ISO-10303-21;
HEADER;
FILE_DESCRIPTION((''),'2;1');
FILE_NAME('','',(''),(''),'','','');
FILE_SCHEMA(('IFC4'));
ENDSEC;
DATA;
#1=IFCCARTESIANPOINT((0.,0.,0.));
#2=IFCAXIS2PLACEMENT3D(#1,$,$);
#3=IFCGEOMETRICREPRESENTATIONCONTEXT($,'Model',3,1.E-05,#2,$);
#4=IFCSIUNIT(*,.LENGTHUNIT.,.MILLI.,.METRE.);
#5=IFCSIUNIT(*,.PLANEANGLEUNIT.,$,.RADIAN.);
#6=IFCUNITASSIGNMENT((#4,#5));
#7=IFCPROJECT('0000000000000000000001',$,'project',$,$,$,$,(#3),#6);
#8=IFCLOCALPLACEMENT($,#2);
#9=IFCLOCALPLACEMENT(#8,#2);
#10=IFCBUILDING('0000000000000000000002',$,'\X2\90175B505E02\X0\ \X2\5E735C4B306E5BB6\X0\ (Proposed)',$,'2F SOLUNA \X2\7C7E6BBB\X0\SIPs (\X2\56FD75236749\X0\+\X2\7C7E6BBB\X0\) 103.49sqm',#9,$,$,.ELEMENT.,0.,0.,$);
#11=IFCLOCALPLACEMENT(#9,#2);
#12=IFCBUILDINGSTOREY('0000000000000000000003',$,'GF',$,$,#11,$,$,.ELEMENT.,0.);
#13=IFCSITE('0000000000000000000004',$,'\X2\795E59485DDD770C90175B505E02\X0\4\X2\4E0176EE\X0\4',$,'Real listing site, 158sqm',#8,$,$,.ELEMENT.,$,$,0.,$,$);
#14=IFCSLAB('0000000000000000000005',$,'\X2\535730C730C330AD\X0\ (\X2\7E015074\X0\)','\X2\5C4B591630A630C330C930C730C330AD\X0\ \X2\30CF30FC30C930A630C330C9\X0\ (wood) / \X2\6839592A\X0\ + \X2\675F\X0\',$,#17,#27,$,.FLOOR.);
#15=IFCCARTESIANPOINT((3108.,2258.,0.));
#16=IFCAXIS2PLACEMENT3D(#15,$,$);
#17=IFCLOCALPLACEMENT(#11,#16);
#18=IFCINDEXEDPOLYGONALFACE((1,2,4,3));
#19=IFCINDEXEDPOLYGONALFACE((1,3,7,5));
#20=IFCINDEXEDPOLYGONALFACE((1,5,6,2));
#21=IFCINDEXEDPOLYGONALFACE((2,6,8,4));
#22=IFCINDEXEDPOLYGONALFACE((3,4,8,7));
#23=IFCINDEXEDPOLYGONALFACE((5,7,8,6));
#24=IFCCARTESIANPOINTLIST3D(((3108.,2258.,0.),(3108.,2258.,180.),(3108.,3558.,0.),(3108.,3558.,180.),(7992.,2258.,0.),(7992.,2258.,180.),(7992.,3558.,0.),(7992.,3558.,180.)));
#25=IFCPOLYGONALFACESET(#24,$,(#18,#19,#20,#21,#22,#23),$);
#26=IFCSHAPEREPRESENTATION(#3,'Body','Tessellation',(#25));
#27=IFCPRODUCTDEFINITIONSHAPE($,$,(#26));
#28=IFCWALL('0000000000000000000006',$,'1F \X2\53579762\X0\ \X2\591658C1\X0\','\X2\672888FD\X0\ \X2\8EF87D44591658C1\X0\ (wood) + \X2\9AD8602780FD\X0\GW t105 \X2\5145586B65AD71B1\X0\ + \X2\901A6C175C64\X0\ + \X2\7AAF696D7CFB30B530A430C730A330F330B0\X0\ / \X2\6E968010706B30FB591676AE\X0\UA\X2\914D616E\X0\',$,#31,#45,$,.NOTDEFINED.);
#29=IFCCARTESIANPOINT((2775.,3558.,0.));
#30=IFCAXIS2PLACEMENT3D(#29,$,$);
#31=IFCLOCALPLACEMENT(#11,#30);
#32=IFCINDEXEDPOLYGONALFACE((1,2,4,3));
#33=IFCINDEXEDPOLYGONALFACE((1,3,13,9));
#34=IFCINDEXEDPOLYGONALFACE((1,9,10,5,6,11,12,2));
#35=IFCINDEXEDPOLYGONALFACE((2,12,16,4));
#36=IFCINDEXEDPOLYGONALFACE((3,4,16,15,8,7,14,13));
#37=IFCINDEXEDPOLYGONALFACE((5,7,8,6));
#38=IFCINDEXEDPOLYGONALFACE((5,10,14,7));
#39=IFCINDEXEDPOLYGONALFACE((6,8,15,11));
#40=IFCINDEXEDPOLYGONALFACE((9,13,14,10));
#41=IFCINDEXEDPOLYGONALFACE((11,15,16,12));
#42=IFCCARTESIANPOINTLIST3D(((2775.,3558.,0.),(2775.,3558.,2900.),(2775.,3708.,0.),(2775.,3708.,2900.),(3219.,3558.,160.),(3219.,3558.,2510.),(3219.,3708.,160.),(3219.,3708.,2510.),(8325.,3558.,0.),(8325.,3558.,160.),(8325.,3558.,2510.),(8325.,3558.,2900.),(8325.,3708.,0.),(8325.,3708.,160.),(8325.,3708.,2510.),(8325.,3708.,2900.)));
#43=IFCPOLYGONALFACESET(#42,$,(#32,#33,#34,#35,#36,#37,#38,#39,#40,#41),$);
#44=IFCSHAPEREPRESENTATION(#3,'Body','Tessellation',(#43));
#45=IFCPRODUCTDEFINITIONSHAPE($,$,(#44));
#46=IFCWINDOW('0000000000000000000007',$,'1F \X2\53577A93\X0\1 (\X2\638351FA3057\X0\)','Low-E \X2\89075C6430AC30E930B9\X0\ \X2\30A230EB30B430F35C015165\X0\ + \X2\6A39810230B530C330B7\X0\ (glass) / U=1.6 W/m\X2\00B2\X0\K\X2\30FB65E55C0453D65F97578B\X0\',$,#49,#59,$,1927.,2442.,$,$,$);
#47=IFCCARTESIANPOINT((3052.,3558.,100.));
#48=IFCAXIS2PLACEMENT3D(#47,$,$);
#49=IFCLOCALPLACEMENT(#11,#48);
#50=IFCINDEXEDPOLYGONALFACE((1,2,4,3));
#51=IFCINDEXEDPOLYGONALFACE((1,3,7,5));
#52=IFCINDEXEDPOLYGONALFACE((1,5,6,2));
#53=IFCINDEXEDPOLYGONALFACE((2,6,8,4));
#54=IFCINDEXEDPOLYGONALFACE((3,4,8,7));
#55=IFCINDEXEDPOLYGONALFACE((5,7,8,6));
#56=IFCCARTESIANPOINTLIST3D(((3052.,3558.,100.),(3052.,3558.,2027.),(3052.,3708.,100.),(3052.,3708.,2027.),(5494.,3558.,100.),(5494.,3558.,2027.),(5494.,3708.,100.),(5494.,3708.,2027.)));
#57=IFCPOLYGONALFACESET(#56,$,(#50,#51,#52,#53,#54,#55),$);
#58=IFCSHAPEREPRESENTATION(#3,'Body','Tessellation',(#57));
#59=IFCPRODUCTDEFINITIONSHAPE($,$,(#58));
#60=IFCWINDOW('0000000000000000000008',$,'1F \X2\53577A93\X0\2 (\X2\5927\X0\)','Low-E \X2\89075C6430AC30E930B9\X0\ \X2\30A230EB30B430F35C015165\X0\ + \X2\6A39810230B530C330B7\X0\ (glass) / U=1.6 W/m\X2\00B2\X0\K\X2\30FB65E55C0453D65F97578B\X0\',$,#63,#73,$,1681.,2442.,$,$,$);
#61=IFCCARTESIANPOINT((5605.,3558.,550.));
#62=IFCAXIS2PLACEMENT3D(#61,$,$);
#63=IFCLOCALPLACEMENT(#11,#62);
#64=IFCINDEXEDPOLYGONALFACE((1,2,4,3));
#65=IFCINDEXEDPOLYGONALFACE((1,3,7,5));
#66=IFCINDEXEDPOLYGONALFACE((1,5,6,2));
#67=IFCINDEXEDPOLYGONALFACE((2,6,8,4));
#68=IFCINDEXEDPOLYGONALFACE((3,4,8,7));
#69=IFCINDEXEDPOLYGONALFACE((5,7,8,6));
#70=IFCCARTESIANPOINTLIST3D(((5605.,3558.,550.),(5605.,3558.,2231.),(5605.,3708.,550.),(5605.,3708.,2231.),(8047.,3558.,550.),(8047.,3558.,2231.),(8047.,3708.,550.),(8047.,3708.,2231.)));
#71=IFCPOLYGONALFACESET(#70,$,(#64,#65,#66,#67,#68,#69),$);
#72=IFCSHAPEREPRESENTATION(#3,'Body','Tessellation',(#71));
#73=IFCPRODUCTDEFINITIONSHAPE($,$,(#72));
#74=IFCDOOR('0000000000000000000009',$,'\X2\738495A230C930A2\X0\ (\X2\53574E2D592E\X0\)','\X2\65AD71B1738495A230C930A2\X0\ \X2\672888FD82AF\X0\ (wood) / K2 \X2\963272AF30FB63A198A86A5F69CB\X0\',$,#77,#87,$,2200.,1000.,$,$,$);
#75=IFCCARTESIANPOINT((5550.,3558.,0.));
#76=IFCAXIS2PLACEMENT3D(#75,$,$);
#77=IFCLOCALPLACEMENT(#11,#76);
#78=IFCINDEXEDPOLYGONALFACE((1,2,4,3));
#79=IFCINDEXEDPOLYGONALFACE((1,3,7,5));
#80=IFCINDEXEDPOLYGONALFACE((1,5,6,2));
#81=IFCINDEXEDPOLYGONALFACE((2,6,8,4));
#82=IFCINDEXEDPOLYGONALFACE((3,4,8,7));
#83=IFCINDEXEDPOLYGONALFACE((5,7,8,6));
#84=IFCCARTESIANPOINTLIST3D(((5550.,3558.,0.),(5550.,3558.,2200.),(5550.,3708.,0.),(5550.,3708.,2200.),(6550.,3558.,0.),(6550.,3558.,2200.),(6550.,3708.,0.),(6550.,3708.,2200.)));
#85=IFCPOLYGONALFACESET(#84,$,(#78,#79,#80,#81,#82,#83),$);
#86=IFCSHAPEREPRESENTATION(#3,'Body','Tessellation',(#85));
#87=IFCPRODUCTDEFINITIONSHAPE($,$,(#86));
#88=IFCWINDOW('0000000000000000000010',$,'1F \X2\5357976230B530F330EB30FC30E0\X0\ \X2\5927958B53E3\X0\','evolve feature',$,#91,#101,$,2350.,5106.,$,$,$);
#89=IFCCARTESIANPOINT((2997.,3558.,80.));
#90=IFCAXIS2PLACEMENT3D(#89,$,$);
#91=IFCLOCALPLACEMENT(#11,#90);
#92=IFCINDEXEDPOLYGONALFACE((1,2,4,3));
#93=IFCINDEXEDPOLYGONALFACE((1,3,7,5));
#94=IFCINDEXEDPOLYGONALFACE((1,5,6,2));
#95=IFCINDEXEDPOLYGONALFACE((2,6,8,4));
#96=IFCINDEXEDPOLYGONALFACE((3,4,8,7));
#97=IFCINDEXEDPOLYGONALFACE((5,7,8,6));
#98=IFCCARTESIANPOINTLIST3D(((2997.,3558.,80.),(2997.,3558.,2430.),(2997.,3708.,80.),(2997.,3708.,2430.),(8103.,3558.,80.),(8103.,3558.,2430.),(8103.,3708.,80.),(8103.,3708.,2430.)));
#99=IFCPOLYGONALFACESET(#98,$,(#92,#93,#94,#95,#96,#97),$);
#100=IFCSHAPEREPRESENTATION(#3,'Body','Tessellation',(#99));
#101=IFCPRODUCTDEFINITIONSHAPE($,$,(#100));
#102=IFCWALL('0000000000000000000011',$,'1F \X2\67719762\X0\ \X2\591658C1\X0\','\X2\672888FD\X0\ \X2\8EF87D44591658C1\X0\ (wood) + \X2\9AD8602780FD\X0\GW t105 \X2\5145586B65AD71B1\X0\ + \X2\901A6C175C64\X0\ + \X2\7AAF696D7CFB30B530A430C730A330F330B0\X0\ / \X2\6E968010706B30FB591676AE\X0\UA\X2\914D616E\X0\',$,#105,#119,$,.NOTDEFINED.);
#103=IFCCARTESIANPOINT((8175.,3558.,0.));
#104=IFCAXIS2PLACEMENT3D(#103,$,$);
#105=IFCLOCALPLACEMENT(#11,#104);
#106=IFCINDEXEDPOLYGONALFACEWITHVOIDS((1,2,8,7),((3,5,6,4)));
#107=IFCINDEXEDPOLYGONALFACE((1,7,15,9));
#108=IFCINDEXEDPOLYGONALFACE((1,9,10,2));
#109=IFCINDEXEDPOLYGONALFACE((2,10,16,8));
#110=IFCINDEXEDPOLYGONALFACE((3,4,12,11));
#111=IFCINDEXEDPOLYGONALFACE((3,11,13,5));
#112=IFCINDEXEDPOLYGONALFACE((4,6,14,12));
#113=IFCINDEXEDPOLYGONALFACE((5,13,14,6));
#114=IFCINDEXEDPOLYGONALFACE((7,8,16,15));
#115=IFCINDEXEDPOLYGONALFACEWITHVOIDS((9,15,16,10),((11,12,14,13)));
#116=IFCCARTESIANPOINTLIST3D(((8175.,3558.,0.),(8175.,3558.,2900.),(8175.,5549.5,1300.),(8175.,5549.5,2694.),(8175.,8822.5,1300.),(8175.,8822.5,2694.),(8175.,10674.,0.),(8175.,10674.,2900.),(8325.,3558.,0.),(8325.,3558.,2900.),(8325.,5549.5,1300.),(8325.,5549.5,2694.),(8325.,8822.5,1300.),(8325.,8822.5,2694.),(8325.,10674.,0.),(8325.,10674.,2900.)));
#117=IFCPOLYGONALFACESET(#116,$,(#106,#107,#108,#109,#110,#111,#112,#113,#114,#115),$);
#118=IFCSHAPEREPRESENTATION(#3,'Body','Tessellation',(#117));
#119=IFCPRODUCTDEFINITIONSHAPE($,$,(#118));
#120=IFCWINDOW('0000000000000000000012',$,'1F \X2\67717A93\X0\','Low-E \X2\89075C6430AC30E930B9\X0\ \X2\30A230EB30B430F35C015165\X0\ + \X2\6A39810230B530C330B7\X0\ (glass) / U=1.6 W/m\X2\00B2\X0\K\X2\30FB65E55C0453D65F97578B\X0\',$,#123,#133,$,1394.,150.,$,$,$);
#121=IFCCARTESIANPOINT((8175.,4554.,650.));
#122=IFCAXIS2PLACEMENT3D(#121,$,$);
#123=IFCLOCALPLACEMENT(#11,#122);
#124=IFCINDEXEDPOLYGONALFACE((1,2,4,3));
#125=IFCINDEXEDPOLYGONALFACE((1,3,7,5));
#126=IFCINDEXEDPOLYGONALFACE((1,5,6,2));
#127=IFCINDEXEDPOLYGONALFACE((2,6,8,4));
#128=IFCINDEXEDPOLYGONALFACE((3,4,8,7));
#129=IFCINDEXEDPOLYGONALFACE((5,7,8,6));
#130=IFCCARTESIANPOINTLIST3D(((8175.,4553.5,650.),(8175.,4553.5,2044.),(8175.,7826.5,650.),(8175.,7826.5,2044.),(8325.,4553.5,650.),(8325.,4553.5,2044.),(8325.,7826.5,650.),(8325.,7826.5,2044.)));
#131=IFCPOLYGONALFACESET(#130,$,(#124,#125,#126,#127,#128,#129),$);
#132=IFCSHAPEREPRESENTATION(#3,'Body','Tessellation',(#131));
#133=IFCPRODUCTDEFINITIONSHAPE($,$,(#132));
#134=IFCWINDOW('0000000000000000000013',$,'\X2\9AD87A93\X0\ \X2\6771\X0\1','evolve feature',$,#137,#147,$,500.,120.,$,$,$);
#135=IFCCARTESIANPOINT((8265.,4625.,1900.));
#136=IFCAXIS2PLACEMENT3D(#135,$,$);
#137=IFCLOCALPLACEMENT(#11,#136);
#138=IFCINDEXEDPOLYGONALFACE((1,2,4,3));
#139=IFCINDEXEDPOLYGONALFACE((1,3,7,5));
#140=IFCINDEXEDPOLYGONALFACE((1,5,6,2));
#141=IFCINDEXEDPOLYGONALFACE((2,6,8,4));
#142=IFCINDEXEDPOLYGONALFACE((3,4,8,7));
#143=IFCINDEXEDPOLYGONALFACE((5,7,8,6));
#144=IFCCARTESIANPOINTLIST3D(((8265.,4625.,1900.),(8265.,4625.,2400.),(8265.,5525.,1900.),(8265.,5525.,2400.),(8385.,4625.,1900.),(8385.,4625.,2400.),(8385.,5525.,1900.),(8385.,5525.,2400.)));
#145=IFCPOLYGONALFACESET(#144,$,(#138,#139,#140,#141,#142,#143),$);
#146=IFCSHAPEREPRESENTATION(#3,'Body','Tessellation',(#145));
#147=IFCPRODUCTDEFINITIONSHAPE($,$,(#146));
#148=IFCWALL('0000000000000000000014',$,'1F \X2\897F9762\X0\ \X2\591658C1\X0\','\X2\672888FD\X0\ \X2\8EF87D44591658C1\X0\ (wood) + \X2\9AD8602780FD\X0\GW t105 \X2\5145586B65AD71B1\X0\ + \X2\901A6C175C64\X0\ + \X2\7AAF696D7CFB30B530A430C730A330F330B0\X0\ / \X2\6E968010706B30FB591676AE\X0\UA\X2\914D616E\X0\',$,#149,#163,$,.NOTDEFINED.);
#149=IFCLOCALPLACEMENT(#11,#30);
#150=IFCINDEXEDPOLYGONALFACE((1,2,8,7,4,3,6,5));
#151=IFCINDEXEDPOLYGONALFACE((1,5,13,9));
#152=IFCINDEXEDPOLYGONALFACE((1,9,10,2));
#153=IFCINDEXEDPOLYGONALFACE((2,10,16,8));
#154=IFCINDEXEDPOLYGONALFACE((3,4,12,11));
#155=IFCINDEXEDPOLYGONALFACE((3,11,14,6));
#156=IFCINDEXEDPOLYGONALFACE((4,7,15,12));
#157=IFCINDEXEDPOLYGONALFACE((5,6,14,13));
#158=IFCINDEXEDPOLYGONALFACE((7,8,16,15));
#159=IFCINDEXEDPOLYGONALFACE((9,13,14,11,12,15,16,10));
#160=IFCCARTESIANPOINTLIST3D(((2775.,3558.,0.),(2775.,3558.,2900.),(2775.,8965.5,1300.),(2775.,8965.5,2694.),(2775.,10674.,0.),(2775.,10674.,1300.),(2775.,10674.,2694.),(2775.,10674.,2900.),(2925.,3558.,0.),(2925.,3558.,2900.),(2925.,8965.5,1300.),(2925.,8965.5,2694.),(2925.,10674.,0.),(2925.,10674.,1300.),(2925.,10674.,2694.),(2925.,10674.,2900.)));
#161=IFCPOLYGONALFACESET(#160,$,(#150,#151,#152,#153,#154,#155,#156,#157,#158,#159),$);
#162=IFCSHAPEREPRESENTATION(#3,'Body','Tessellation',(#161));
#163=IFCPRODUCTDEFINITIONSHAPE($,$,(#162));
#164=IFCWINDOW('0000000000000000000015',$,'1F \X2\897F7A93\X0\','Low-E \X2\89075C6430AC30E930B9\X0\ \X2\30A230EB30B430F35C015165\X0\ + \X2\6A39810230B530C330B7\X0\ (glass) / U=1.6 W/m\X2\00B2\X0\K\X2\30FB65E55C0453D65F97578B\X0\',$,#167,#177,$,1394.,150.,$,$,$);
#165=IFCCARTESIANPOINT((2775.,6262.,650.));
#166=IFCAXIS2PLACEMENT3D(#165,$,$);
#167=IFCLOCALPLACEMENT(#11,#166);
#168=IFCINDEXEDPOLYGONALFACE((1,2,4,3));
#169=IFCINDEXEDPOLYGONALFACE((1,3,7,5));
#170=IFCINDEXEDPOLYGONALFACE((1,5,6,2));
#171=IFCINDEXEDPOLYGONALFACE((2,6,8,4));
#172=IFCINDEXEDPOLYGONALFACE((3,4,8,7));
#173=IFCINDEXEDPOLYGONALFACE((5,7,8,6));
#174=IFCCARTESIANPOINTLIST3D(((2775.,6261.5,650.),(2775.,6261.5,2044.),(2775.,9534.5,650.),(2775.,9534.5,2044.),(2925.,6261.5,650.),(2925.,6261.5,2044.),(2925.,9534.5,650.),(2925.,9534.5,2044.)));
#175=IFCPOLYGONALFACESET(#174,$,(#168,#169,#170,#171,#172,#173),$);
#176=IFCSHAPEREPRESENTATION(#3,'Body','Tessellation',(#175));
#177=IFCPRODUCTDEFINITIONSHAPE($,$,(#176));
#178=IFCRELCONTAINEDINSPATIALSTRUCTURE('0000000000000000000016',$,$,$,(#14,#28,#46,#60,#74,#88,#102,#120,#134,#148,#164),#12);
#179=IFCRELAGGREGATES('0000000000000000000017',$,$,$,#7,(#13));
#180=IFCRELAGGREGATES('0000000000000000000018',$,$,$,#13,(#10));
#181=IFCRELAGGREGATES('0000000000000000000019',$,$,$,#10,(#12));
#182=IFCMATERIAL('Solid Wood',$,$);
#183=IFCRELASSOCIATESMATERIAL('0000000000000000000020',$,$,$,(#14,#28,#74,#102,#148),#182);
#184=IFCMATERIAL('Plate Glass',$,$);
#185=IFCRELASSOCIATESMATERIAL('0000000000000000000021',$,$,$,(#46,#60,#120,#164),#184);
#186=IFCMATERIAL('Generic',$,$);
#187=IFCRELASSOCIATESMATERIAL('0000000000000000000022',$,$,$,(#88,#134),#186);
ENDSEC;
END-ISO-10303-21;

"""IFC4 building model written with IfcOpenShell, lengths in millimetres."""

from ifc_helpers import new_model, si_unit, frame, frame_2d, origin, place, context, project, spatial, rectangle, extrude, material, element, fill, save


model = new_model("IFC4")

# Units and contexts
model_context = context("Model", 3, precision=1e-05, world=origin())
ifc_project = project(units=[si_unit("LENGTHUNIT", "METRE", prefix="MILLI"), si_unit("PLANEANGLEUNIT", "RADIAN")], contexts=[model_context])

# Site, building, storey
site_placement = place(None, origin())
site = spatial("IfcSite", under=ifc_project, at=site_placement, Name="神奈川県逗子市4丁目4", ObjectType="Real listing site, 158sqm", CompositionType="ELEMENT", RefElevation=0.0)
building_placement = place(site_placement, origin())
building = spatial("IfcBuilding", under=site, at=building_placement, Name="逗子市 平屋の家 (Proposed)", ObjectType="2F SOLUNA 籾殻SIPs (国産杉+籾殻) 103.49sqm", CompositionType="ELEMENT", ElevationOfRefHeight=0.0, ElevationOfTerrain=0.0)
storey_placement = place(building_placement, origin())
storey = spatial("IfcBuildingStorey", under=building, at=storey_placement, Name="GF", CompositionType="ELEMENT", Elevation=0.0)

# Slab
ifc_material_1 = material(Name="Solid Wood")
slab_1_placement = place(storey_placement, frame((3108.0, 2258.0, 0.0)))
element("IfcSlab", 1, at=slab_1_placement, inside=storey, material=ifc_material_1, Name="南デッキ (縁側)", Description="屋外ウッドデッキ ハードウッド (wood) / 根太 + 束", PredefinedType="FLOOR", context=model_context, shape_type="SweptSolid", body=[
    extrude(rectangle(XDim=4884.0, YDim=1300.0, at=frame_2d((2442.0, 650.0))), frame((3108.0, 2258.0, 0.0)), (0.0, 0.0, 1.0), 180.0),
])
ifc_material_2 = material(Name="Generic")

# Wall, openings, windows, door
wall_1_placement = place(storey_placement, frame((2775.0, 3558.0, 0.0)))
wall_1 = element("IfcWall", 2, at=wall_1_placement, inside=storey, material=ifc_material_1, Name="1F 南面 外壁", Description="木製 軸組外壁 (wood) + 高性能GW t105 充填断熱 + 通気層 + 窯業系サイディング / 準耐火・外皮UA配慮", PredefinedType="NOTDEFINED", context=model_context, shape_type="SweptSolid", body=[
    extrude(rectangle(XDim=5550.0, YDim=150.0, at=frame_2d((2775.0, 75.0))), frame((2775.0, 3558.0, 0.0)), (0.0, 0.0, 1.0), 2900.0),
])
opening_1_placement = place(storey_placement, frame((3052.0, 3558.0, 100.0)))
opening_1 = element("IfcOpeningElement", 3, at=opening_1_placement, cuts=wall_1, PredefinedType="NOTDEFINED", context=model_context, shape_type="SweptSolid", body=[
    extrude(rectangle(XDim=2442.0, YDim=150.0, at=frame_2d((1221.0, 75.0))), frame((3052.0, 3558.0, 100.0)), (0.0, 0.0, 1.0), 1927.0),
])
opening_2_placement = place(storey_placement, frame((5605.0, 3558.0, 550.0)))
opening_2 = element("IfcOpeningElement", 4, at=opening_2_placement, cuts=wall_1, PredefinedType="NOTDEFINED", context=model_context, shape_type="SweptSolid", body=[
    extrude(rectangle(XDim=2442.0, YDim=150.0, at=frame_2d((1221.0, 75.0))), frame((5605.0, 3558.0, 550.0)), (0.0, 0.0, 1.0), 1681.0),
])
opening_3_placement = place(storey_placement, frame((5550.0, 3558.0, 0.0)))
opening_3 = element("IfcOpeningElement", 5, at=opening_3_placement, cuts=wall_1, PredefinedType="NOTDEFINED", context=model_context, shape_type="SweptSolid", body=[
    extrude(rectangle(XDim=1000.0, YDim=150.0, at=frame_2d((500.0, 75.0))), frame((5550.0, 3558.0, 0.0)), (0.0, 0.0, 1.0), 2200.0),
])
opening_4_placement = place(storey_placement, frame((2997.0, 3558.0, 80.0)))
opening_4 = element("IfcOpeningElement", 6, at=opening_4_placement, cuts=wall_1, PredefinedType="NOTDEFINED", context=model_context, shape_type="SweptSolid", body=[
    extrude(rectangle(XDim=5106.0, YDim=150.0, at=frame_2d((2553.0, 75.0))), frame((2997.0, 3558.0, 80.0)), (0.0, 0.0, 1.0), 2350.0),
])
ifc_material_3 = material(Name="Plate Glass")
window_1_placement = place(storey_placement, frame((3052.0, 3558.0, 100.0)))
window_1 = element("IfcWindow", 7, at=window_1_placement, inside=storey, material=ifc_material_3, Name="1F 南窓1 (掃出し)", Description="Low-E 複層ガラス アルゴン封入 + 樹脂サッシ (glass) / U=1.6 W/m²K・日射取得型", OverallHeight=1927.0, OverallWidth=2442.0, context=model_context, shape_type="SweptSolid", body=[
    extrude(rectangle(XDim=2442.0, YDim=150.0, at=frame_2d((1221.0, 75.0))), frame((3052.0, 3558.0, 100.0)), (0.0, 0.0, 1.0), 1927.0),
])
fill(opening_1, window_1)
window_2_placement = place(storey_placement, frame((5605.0, 3558.0, 550.0)))
window_2 = element("IfcWindow", 8, at=window_2_placement, inside=storey, material=ifc_material_3, Name="1F 南窓2 (大)", Description="Low-E 複層ガラス アルゴン封入 + 樹脂サッシ (glass) / U=1.6 W/m²K・日射取得型", OverallHeight=1681.0, OverallWidth=2442.0, context=model_context, shape_type="SweptSolid", body=[
    extrude(rectangle(XDim=2442.0, YDim=150.0, at=frame_2d((1221.0, 75.0))), frame((5605.0, 3558.0, 550.0)), (0.0, 0.0, 1.0), 1681.0),
])
fill(opening_2, window_2)
door_placement = place(storey_placement, frame((5550.0, 3558.0, 0.0)))
door = element("IfcDoor", 9, at=door_placement, inside=storey, material=ifc_material_1, Name="玄関ドア (南中央)", Description="断熱玄関ドア 木製芯 (wood) / K2 防犯・採風機構", OverallHeight=2200.0, OverallWidth=1000.0, context=model_context, shape_type="SweptSolid", body=[
    extrude(rectangle(XDim=1000.0, YDim=150.0, at=frame_2d((500.0, 75.0))), frame((5550.0, 3558.0, 0.0)), (0.0, 0.0, 1.0), 2200.0),
])
fill(opening_3, door)
window_3_placement = place(storey_placement, frame((2997.0, 3558.0, 80.0)))
window_3 = element("IfcWindow", 10, at=window_3_placement, inside=storey, material=ifc_material_2, Name="1F 南面サンルーム 大開口", Description="evolve feature", OverallHeight=2350.0, OverallWidth=5106.0, context=model_context, shape_type="SweptSolid", body=[
    extrude(rectangle(XDim=5106.0, YDim=150.0, at=frame_2d((2553.0, 75.0))), frame((2997.0, 3558.0, 80.0)), (0.0, 0.0, 1.0), 2350.0),
])
fill(opening_4, window_3)

# Wall, openings, windows
wall_2_placement = place(storey_placement, frame((8175.0, 3558.0, 0.0)))
wall_2 = element("IfcWall", 11, at=wall_2_placement, inside=storey, material=ifc_material_1, Name="1F 東面 外壁", Description="木製 軸組外壁 (wood) + 高性能GW t105 充填断熱 + 通気層 + 窯業系サイディング / 準耐火・外皮UA配慮", PredefinedType="NOTDEFINED", context=model_context, shape_type="SweptSolid", body=[
    extrude(rectangle(XDim=150.0, YDim=7116.0, at=frame_2d((75.0, 3558.0))), frame((8175.0, 3558.0, 0.0)), (0.0, 0.0, 1.0), 2900.0),
])
opening_5_placement = place(storey_placement, frame((8175.0, 4554.0, 650.0)))
opening_5 = element("IfcOpeningElement", 12, at=opening_5_placement, cuts=wall_2, PredefinedType="NOTDEFINED", context=model_context, shape_type="SweptSolid", body=[
    extrude(rectangle(XDim=150.0, YDim=3273.0, at=frame_2d((75.0, 1636.0))), frame((8175.0, 4554.0, 650.0)), (0.0, 0.0, 1.0), 1394.0),
])
opening_6_placement = place(storey_placement, frame((8265.0, 4625.0, 1900.0)))
opening_6 = element("IfcOpeningElement", 13, at=opening_6_placement, cuts=wall_2, PredefinedType="NOTDEFINED", context=model_context, shape_type="SweptSolid", body=[
    extrude(rectangle(XDim=120.0, YDim=900.0, at=frame_2d((60.0, 450.0))), frame((8265.0, 4625.0, 1900.0)), (0.0, 0.0, 1.0), 500.0),
])
window_4_placement = place(storey_placement, frame((8175.0, 4554.0, 650.0)))
window_4 = element("IfcWindow", 14, at=window_4_placement, inside=storey, material=ifc_material_3, Name="1F 東窓", Description="Low-E 複層ガラス アルゴン封入 + 樹脂サッシ (glass) / U=1.6 W/m²K・日射取得型", OverallHeight=1394.0, OverallWidth=150.0, context=model_context, shape_type="SweptSolid", body=[
    extrude(rectangle(XDim=150.0, YDim=3273.0, at=frame_2d((75.0, 1636.0))), frame((8175.0, 4554.0, 650.0)), (0.0, 0.0, 1.0), 1394.0),
])
fill(opening_5, window_4)
window_5_placement = place(storey_placement, frame((8265.0, 4625.0, 1900.0)))
window_5 = element("IfcWindow", 15, at=window_5_placement, inside=storey, material=ifc_material_2, Name="高窓 東1", Description="evolve feature", OverallHeight=500.0, OverallWidth=120.0, context=model_context, shape_type="SweptSolid", body=[
    extrude(rectangle(XDim=120.0, YDim=900.0, at=frame_2d((60.0, 450.0))), frame((8265.0, 4625.0, 1900.0)), (0.0, 0.0, 1.0), 500.0),
])
fill(opening_6, window_5)

# Wall, opening, window
wall_3_placement = place(storey_placement, frame((2775.0, 3558.0, 0.0)))
wall_3 = element("IfcWall", 16, at=wall_3_placement, inside=storey, material=ifc_material_1, Name="1F 西面 外壁", Description="木製 軸組外壁 (wood) + 高性能GW t105 充填断熱 + 通気層 + 窯業系サイディング / 準耐火・外皮UA配慮", PredefinedType="NOTDEFINED", context=model_context, shape_type="SweptSolid", body=[
    extrude(rectangle(XDim=150.0, YDim=7116.0, at=frame_2d((75.0, 3558.0))), frame((2775.0, 3558.0, 0.0)), (0.0, 0.0, 1.0), 2900.0),
])
opening_7_placement = place(storey_placement, frame((2775.0, 6262.0, 650.0)))
opening_7 = element("IfcOpeningElement", 17, at=opening_7_placement, cuts=wall_3, PredefinedType="NOTDEFINED", context=model_context, shape_type="SweptSolid", body=[
    extrude(rectangle(XDim=150.0, YDim=3273.0, at=frame_2d((75.0, 1636.0))), frame((2775.0, 6262.0, 650.0)), (0.0, 0.0, 1.0), 1394.0),
])
window_6_placement = place(storey_placement, frame((2775.0, 6262.0, 650.0)))
window_6 = element("IfcWindow", 18, at=window_6_placement, inside=storey, material=ifc_material_3, Name="1F 西窓", Description="Low-E 複層ガラス アルゴン封入 + 樹脂サッシ (glass) / U=1.6 W/m²K・日射取得型", OverallHeight=1394.0, OverallWidth=150.0, context=model_context, shape_type="SweptSolid", body=[
    extrude(rectangle(XDim=150.0, YDim=3273.0, at=frame_2d((75.0, 1636.0))), frame((2775.0, 6262.0, 650.0)), (0.0, 0.0, 1.0), 1394.0),
])
fill(opening_7, window_6)

save(model, "model.ifc")
